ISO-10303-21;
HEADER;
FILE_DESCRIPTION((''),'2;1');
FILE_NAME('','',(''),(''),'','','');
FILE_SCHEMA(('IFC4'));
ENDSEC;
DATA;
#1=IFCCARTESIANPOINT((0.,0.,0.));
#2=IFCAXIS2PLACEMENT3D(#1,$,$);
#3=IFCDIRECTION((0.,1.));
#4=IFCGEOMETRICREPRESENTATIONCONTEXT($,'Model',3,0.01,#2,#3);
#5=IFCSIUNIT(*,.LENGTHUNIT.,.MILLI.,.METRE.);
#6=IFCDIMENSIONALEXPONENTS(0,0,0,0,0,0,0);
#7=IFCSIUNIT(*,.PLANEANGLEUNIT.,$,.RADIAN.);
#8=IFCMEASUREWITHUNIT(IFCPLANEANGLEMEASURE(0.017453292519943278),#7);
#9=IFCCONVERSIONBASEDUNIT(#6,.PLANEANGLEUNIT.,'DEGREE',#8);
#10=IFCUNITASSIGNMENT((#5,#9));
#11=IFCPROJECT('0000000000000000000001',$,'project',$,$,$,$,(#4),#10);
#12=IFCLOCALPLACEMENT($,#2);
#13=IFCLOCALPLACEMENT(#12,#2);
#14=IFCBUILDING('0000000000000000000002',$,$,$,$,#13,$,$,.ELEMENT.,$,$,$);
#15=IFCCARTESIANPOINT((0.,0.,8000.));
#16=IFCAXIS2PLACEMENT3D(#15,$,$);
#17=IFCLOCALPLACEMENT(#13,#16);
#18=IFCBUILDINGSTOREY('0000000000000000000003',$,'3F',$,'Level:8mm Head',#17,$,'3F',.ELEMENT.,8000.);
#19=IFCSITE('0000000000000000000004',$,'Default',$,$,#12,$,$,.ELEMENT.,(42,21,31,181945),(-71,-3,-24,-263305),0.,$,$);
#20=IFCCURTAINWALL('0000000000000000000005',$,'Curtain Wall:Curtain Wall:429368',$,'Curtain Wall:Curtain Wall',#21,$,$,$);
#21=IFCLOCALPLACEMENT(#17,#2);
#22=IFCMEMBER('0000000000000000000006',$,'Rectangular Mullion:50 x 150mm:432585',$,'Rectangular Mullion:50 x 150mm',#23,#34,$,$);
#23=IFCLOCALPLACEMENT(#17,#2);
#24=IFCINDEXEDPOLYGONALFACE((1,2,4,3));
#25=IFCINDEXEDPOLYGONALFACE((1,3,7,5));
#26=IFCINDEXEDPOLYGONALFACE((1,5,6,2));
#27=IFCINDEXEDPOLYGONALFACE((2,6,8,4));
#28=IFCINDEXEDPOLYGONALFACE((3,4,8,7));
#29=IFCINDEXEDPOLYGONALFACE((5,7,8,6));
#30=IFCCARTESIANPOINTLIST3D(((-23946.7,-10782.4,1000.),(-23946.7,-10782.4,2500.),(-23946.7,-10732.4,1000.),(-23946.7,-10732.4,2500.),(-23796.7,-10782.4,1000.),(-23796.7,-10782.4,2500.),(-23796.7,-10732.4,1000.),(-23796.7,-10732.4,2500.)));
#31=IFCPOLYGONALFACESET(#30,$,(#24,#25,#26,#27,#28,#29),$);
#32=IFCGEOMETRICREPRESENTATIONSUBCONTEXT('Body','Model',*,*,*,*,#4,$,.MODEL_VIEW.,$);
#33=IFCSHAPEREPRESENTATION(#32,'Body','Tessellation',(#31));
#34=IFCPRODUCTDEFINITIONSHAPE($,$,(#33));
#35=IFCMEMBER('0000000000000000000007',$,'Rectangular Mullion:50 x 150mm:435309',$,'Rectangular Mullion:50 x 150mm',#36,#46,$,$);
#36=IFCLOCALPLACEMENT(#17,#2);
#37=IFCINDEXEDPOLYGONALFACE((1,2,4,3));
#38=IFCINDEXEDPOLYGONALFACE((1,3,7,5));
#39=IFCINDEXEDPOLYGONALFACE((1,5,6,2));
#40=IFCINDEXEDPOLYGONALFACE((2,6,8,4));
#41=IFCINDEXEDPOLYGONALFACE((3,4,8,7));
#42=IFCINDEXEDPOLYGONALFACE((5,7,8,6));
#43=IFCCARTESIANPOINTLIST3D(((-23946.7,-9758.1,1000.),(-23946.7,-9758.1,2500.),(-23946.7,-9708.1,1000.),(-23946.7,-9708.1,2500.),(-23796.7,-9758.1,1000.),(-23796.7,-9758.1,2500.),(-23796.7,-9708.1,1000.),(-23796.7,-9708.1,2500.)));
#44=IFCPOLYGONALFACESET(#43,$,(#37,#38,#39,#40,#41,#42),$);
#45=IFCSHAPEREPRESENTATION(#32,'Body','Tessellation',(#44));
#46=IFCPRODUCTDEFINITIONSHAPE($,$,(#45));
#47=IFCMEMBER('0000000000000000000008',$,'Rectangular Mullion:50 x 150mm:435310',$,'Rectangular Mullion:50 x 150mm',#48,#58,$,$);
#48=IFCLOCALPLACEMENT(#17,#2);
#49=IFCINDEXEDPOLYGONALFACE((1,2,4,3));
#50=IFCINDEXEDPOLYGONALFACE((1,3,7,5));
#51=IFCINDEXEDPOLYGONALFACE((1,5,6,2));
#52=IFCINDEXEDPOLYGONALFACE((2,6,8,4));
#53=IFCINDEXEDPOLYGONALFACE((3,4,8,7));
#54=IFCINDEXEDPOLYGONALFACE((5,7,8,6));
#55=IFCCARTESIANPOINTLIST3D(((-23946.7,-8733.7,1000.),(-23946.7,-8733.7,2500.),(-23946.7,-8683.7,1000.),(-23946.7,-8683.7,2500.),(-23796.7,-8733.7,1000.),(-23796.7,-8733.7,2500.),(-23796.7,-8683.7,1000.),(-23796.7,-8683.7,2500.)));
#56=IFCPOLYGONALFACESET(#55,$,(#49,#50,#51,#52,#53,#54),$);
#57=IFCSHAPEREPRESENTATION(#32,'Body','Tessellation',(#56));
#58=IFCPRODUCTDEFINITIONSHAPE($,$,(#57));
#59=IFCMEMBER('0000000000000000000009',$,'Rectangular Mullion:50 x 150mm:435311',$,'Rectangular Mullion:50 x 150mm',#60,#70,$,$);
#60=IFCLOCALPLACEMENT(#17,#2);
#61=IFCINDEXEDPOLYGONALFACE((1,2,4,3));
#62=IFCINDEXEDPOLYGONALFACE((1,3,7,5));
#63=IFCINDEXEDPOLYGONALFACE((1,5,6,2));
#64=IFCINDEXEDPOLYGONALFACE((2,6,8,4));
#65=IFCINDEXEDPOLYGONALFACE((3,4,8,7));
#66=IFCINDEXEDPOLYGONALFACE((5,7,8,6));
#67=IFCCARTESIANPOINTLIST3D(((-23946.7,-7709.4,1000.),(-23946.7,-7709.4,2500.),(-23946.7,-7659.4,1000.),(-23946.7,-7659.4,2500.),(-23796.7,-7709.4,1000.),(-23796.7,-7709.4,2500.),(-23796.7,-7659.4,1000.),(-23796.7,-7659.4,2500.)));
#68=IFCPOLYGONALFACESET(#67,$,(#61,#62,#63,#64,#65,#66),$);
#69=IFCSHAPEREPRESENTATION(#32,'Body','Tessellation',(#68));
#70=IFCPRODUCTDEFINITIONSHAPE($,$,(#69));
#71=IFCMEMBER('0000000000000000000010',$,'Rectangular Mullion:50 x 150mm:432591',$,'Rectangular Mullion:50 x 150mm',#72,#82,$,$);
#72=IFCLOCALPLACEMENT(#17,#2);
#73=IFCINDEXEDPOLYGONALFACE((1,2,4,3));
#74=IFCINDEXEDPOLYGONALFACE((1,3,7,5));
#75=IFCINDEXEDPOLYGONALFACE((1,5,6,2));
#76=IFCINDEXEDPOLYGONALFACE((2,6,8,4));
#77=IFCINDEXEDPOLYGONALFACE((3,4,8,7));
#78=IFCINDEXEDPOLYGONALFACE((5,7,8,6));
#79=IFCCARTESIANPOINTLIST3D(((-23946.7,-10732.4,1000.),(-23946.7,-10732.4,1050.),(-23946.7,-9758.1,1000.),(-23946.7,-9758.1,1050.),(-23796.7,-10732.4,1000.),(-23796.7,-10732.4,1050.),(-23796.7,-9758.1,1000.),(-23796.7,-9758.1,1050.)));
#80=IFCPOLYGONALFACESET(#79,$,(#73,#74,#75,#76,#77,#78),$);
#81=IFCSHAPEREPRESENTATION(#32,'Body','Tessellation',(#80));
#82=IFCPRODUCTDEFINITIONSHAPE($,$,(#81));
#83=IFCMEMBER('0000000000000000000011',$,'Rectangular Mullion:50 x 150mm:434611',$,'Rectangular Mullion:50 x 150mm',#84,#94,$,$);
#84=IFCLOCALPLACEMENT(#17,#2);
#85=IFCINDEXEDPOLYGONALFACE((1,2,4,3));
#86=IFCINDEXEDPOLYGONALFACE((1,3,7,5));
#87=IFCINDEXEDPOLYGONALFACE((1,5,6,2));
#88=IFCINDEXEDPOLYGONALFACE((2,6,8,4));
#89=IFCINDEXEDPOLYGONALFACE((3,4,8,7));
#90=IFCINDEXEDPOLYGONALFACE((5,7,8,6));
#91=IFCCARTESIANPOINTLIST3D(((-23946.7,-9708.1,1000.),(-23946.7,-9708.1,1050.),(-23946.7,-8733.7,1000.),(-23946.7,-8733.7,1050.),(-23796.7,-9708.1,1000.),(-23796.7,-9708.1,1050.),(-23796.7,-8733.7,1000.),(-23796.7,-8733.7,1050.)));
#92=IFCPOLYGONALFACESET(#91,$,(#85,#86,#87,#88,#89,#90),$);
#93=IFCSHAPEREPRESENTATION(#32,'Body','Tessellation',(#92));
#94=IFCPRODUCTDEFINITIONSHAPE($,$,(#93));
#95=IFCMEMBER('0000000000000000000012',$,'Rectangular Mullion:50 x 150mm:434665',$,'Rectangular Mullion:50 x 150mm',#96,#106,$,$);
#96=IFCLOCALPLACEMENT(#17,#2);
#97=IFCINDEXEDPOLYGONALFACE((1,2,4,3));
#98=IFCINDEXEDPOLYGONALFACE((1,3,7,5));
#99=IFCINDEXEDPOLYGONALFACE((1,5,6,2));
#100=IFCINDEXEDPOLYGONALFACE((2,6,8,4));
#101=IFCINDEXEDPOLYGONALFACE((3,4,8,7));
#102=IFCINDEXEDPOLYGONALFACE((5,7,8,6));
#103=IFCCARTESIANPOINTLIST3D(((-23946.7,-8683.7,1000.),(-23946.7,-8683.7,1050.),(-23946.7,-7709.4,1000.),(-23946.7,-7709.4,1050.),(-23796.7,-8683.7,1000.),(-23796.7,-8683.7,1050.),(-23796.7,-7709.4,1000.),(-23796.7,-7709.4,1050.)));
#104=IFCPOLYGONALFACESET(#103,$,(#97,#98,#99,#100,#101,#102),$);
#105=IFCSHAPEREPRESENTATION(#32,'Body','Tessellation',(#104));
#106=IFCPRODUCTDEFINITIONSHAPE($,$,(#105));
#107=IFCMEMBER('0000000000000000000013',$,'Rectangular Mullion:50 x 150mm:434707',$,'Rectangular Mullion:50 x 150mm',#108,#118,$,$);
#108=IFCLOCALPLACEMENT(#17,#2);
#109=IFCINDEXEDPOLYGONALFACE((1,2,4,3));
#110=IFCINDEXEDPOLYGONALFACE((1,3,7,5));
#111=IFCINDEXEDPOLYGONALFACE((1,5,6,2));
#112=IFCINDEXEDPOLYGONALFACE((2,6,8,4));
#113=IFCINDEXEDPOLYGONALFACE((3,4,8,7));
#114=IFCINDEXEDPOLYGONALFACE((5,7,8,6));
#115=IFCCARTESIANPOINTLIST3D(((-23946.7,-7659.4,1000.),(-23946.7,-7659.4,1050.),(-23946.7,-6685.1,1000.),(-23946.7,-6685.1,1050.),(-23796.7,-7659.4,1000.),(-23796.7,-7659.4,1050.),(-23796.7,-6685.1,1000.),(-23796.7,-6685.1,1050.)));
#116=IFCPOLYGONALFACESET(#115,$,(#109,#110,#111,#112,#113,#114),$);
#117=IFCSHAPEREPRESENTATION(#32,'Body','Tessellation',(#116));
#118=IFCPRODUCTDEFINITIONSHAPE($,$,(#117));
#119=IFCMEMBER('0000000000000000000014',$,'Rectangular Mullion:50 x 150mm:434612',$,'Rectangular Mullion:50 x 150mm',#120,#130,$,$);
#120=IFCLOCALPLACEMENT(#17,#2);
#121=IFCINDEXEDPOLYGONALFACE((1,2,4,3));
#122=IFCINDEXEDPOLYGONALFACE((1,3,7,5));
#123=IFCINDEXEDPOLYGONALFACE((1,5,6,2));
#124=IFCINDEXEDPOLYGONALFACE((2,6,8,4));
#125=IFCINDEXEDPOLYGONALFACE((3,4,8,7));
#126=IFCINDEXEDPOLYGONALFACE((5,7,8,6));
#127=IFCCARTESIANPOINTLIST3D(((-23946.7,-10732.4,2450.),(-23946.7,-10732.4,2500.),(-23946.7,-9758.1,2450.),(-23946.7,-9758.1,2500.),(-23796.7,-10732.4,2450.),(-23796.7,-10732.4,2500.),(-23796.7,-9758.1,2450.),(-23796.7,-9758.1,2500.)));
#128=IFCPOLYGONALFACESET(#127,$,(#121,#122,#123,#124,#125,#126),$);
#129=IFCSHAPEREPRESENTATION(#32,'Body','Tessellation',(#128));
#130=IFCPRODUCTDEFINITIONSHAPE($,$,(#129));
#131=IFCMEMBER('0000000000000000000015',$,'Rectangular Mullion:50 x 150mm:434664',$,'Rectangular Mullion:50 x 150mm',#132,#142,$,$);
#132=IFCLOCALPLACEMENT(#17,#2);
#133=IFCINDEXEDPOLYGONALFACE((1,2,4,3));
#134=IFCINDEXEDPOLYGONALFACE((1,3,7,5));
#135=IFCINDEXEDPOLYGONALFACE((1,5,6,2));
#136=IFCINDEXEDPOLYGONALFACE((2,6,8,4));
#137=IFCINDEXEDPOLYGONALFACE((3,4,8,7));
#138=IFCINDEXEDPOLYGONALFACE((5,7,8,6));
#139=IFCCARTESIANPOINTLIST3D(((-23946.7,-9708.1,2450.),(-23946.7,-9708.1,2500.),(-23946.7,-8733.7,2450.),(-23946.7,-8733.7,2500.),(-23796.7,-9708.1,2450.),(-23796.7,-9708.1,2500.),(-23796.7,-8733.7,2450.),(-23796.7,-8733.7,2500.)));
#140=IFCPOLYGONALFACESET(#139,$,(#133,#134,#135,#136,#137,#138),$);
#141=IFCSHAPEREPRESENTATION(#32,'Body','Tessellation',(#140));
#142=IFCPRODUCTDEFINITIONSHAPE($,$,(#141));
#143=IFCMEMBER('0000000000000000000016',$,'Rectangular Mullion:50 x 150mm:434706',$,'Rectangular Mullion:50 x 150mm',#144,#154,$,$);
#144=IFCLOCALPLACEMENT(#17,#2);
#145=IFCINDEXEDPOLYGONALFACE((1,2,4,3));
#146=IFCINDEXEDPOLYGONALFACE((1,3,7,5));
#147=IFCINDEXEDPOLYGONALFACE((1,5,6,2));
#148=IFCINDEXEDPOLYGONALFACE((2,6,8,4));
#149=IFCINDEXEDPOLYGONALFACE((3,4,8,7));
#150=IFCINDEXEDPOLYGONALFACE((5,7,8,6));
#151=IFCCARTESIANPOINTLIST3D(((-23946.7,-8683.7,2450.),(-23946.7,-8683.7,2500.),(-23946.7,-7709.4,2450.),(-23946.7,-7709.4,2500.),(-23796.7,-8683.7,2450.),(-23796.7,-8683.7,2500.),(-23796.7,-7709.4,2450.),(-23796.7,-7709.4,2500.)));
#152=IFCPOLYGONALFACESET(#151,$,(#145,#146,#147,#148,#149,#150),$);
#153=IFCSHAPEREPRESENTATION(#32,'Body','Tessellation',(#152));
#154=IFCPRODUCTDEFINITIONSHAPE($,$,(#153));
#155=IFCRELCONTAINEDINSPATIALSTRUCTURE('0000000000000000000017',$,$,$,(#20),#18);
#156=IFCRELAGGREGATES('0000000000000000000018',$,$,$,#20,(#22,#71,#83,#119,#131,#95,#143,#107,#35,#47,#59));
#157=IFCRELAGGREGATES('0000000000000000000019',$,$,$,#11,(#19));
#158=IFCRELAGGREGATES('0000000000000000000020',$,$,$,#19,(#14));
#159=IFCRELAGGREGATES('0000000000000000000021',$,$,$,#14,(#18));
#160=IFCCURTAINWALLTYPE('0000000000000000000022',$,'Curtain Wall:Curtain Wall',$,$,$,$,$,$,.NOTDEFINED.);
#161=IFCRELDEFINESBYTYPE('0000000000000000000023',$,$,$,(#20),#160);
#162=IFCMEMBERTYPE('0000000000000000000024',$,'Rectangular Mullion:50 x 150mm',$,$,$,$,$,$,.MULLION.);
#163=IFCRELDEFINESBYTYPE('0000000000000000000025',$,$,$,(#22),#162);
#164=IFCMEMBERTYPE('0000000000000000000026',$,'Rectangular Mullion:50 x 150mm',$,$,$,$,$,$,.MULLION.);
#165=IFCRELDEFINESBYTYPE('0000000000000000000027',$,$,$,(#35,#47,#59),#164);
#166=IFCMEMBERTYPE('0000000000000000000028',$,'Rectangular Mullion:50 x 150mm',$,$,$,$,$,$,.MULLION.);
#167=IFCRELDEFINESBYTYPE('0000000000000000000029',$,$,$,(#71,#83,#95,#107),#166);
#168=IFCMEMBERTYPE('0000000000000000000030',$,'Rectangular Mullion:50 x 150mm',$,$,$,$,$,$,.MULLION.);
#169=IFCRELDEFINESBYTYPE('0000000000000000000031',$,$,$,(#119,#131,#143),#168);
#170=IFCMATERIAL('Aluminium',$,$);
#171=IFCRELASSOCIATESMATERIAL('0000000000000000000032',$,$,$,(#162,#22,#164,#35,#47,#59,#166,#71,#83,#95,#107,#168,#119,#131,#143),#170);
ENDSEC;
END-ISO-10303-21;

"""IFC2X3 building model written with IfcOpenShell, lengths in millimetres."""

from ifc_helpers import new_model, entity, si_unit, converted_unit, direction, frame, origin, origin_2d_with_axis, place, context, subcontext, project, spatial, rectangle, extrude, source, transform, mapped, material, type_object, type_shapes, element, aggregate, save


model = new_model("IFC2X3")

# Units and contexts
model_context = context("Model", 3, precision=0.01, world=origin(), true_north=direction((0.0, 1.0)))
body_context = subcontext(model_context, "Body", "Model", "MODEL_VIEW")
ifc_project = project(units=[si_unit("LENGTHUNIT", "METRE", prefix="MILLI"), converted_unit("PLANEANGLEUNIT", "DEGREE", entity("IfcPlaneAngleMeasure", 0.017453292519943278), si_unit("PLANEANGLEUNIT", "RADIAN"), dimensions=[0, 0, 0, 0, 0, 0, 0])], contexts=[model_context])

# Site, building, storey
site_placement = place(None, origin())
site = spatial("IfcSite", under=ifc_project, at=site_placement, Name="Default", CompositionType="ELEMENT", RefLatitude=(42, 21, 31, 181945), RefLongitude=(-71, -3, -24, -263305), RefElevation=0.0)
building_placement = place(site_placement, origin())
building = spatial("IfcBuilding", under=site, at=building_placement, CompositionType="ELEMENT")
storey_placement = place(building_placement, frame((0.0, 0.0, 8000.0)))
storey = spatial("IfcBuildingStorey", under=building, at=storey_placement, Name="3F", ObjectType="Level:8mm Head", LongName="3F", CompositionType="ELEMENT", Elevation=8000.0)

# Curtain wall, members
curtain_wall_type = type_object("IfcCurtainWallType", Name="Curtain Wall:Curtain Wall", PredefinedType="NOTDEFINED")
curtain_wall_placement = place(storey_placement, frame((0.0, 0.0, -8000.0)))
curtain_wall = element("IfcCurtainWall", 1, at=curtain_wall_placement, inside=storey, type_object=curtain_wall_type, Name="Curtain Wall:Curtain Wall:429368", ObjectType="Curtain Wall:Curtain Wall")
ifc_material_1 = material(Name="Aluminium")
member_type_1 = type_object("IfcMemberType", Name="Rectangular Mullion:50 x 150mm", PredefinedType="MULLION", material=ifc_material_1)
shared_shape_1 = source(origin(), body_context, "Body", "SweptSolid", [
    extrude(rectangle(XDim=50.0, YDim=150.0, at=origin_2d_with_axis()), frame((-25.0, 0.0, -1500.0), z_axis=(0.0, 0.0, 1.0), x_axis=(-1.0, 0.0, 0.0)), (0.0, 0.0, 1.0), 1500.0),
])
type_shapes(member_type_1, [shared_shape_1])
member_1_placement = place(curtain_wall_placement, frame((-23871.7, -10782.4, 10500.0), z_axis=(0.0, 0.0, 1.0), x_axis=(0.0, -1.0, 0.0)))
member_1 = element("IfcMember", 2, at=member_1_placement, type_object=member_type_1, material=ifc_material_1, Name="Rectangular Mullion:50 x 150mm:432585", ObjectType="Rectangular Mullion:50 x 150mm", context=body_context, shape_type="MappedRepresentation", body=[
    mapped(shared_shape_1, transform((0.0, 0.0, 0.0), scale=1.0)),
])
member_type_2 = type_object("IfcMemberType", Name="Rectangular Mullion:50 x 150mm", PredefinedType="MULLION", material=ifc_material_1)
shared_shape_2 = source(origin(), body_context, "Body", "SweptSolid", [
    extrude(rectangle(XDim=50.0, YDim=150.0, at=origin_2d_with_axis()), frame((0.0, 0.0, -1500.0), z_axis=(0.0, 0.0, 1.0), x_axis=(-1.0, 0.0, 0.0)), (0.0, 0.0, 1.0), 1500.0),
])
type_shapes(member_type_2, [shared_shape_2])
member_2_placement = place(curtain_wall_placement, frame((-23871.7, -9733.1, 9000.0), z_axis=(0.0, 0.0, -1.0), x_axis=(0.0, 1.0, 0.0)))
member_2 = element("IfcMember", 3, at=member_2_placement, type_object=member_type_2, material=ifc_material_1, Name="Rectangular Mullion:50 x 150mm:435309", ObjectType="Rectangular Mullion:50 x 150mm", context=body_context, shape_type="MappedRepresentation", body=[
    mapped(shared_shape_2, transform((0.0, 0.0, 0.0), scale=1.0)),
])
member_3_placement = place(curtain_wall_placement, frame((-23871.7, -8708.7, 9000.0), z_axis=(0.0, 0.0, -1.0), x_axis=(0.0, 1.0, 0.0)))
member_3 = element("IfcMember", 4, at=member_3_placement, type_object=member_type_2, material=ifc_material_1, Name="Rectangular Mullion:50 x 150mm:435310", ObjectType="Rectangular Mullion:50 x 150mm", context=body_context, shape_type="MappedRepresentation", body=[
    mapped(shared_shape_2, transform((0.0, 0.0, 0.0), scale=1.0)),
])
member_4_placement = place(curtain_wall_placement, frame((-23871.7, -7684.4, 9000.0), z_axis=(0.0, 0.0, -1.0), x_axis=(0.0, 1.0, 0.0)))
member_4 = element("IfcMember", 5, at=member_4_placement, type_object=member_type_2, material=ifc_material_1, Name="Rectangular Mullion:50 x 150mm:435311", ObjectType="Rectangular Mullion:50 x 150mm", context=body_context, shape_type="MappedRepresentation", body=[
    mapped(shared_shape_2, transform((0.0, 0.0, 0.0), scale=1.0)),
])
member_type_3 = type_object("IfcMemberType", Name="Rectangular Mullion:50 x 150mm", PredefinedType="MULLION", material=ifc_material_1)
shared_shape_3 = source(origin(), body_context, "Body", "SweptSolid", [
    extrude(rectangle(XDim=50.0, YDim=150.0, at=origin_2d_with_axis()), frame((-25.0, 0.0, -974.3), z_axis=(0.0, 0.0, 1.0), x_axis=(-1.0, 0.0, 0.0)), (0.0, 0.0, 1.0), 974.3),
])
type_shapes(member_type_3, [shared_shape_3])
member_5_placement = place(curtain_wall_placement, frame((-23871.7, -10732.4, 9000.0), z_axis=(0.0, -1.0, 0.0), x_axis=(0.0, 0.0, -1.0)))
member_5 = element("IfcMember", 6, at=member_5_placement, type_object=member_type_3, material=ifc_material_1, Name="Rectangular Mullion:50 x 150mm:432591", ObjectType="Rectangular Mullion:50 x 150mm", context=body_context, shape_type="MappedRepresentation", body=[
    mapped(shared_shape_3, transform((0.0, 0.0, 0.0), scale=1.0)),
])
member_6_placement = place(curtain_wall_placement, frame((-23871.7, -9708.1, 9000.0), z_axis=(0.0, -1.0, 0.0), x_axis=(0.0, 0.0, -1.0)))
member_6 = element("IfcMember", 7, at=member_6_placement, type_object=member_type_3, material=ifc_material_1, Name="Rectangular Mullion:50 x 150mm:434611", ObjectType="Rectangular Mullion:50 x 150mm", context=body_context, shape_type="MappedRepresentation", body=[
    mapped(shared_shape_3, transform((0.0, 0.0, 0.0), scale=1.0)),
])
member_7_placement = place(curtain_wall_placement, frame((-23871.7, -8683.7, 9000.0), z_axis=(0.0, -1.0, 0.0), x_axis=(0.0, 0.0, -1.0)))
member_7 = element("IfcMember", 8, at=member_7_placement, type_object=member_type_3, material=ifc_material_1, Name="Rectangular Mullion:50 x 150mm:434665", ObjectType="Rectangular Mullion:50 x 150mm", context=body_context, shape_type="MappedRepresentation", body=[
    mapped(shared_shape_3, transform((0.0, 0.0, 0.0), scale=1.0)),
])
member_8_placement = place(curtain_wall_placement, frame((-23871.7, -7659.4, 9000.0), z_axis=(0.0, -1.0, 0.0), x_axis=(0.0, 0.0, -1.0)))
member_8 = element("IfcMember", 9, at=member_8_placement, type_object=member_type_3, material=ifc_material_1, Name="Rectangular Mullion:50 x 150mm:434707", ObjectType="Rectangular Mullion:50 x 150mm", context=body_context, shape_type="MappedRepresentation", body=[
    mapped(shared_shape_3, transform((0.0, 0.0, 0.0), scale=1.0)),
])
member_type_4 = type_object("IfcMemberType", Name="Rectangular Mullion:50 x 150mm", PredefinedType="MULLION", material=ifc_material_1)
shared_shape_4 = source(origin(), body_context, "Body", "SweptSolid", [
    extrude(rectangle(XDim=50.0, YDim=150.0, at=origin_2d_with_axis()), frame((-25.0, 0.0, -974.3), z_axis=(0.0, 0.0, 1.0), x_axis=(-1.0, 0.0, 0.0)), (0.0, 0.0, 1.0), 974.3),
])
type_shapes(member_type_4, [shared_shape_4])
member_9_placement = place(curtain_wall_placement, frame((-23871.7, -9758.1, 10500.0), z_axis=(0.0, 1.0, 0.0), x_axis=(0.0, 0.0, 1.0)))
member_9 = element("IfcMember", 10, at=member_9_placement, type_object=member_type_4, material=ifc_material_1, Name="Rectangular Mullion:50 x 150mm:434612", ObjectType="Rectangular Mullion:50 x 150mm", context=body_context, shape_type="MappedRepresentation", body=[
    mapped(shared_shape_4, transform((0.0, 0.0, 0.0), scale=1.0)),
])
member_10_placement = place(curtain_wall_placement, frame((-23871.7, -8733.7, 10500.0), z_axis=(0.0, 1.0, 0.0), x_axis=(0.0, 0.0, 1.0)))
member_10 = element("IfcMember", 11, at=member_10_placement, type_object=member_type_4, material=ifc_material_1, Name="Rectangular Mullion:50 x 150mm:434664", ObjectType="Rectangular Mullion:50 x 150mm", context=body_context, shape_type="MappedRepresentation", body=[
    mapped(shared_shape_4, transform((0.0, 0.0, 0.0), scale=1.0)),
])
member_11_placement = place(curtain_wall_placement, frame((-23871.7, -7709.4, 10500.0), z_axis=(0.0, 1.0, 0.0), x_axis=(0.0, 0.0, 1.0)))
member_11 = element("IfcMember", 12, at=member_11_placement, type_object=member_type_4, material=ifc_material_1, Name="Rectangular Mullion:50 x 150mm:434706", ObjectType="Rectangular Mullion:50 x 150mm", context=body_context, shape_type="MappedRepresentation", body=[
    mapped(shared_shape_4, transform((0.0, 0.0, 0.0), scale=1.0)),
])

aggregate(curtain_wall, [member_1, member_5, member_6, member_9, member_10, member_7, member_11, member_8, member_2, member_3, member_4])

save(model, "model.ifc")
